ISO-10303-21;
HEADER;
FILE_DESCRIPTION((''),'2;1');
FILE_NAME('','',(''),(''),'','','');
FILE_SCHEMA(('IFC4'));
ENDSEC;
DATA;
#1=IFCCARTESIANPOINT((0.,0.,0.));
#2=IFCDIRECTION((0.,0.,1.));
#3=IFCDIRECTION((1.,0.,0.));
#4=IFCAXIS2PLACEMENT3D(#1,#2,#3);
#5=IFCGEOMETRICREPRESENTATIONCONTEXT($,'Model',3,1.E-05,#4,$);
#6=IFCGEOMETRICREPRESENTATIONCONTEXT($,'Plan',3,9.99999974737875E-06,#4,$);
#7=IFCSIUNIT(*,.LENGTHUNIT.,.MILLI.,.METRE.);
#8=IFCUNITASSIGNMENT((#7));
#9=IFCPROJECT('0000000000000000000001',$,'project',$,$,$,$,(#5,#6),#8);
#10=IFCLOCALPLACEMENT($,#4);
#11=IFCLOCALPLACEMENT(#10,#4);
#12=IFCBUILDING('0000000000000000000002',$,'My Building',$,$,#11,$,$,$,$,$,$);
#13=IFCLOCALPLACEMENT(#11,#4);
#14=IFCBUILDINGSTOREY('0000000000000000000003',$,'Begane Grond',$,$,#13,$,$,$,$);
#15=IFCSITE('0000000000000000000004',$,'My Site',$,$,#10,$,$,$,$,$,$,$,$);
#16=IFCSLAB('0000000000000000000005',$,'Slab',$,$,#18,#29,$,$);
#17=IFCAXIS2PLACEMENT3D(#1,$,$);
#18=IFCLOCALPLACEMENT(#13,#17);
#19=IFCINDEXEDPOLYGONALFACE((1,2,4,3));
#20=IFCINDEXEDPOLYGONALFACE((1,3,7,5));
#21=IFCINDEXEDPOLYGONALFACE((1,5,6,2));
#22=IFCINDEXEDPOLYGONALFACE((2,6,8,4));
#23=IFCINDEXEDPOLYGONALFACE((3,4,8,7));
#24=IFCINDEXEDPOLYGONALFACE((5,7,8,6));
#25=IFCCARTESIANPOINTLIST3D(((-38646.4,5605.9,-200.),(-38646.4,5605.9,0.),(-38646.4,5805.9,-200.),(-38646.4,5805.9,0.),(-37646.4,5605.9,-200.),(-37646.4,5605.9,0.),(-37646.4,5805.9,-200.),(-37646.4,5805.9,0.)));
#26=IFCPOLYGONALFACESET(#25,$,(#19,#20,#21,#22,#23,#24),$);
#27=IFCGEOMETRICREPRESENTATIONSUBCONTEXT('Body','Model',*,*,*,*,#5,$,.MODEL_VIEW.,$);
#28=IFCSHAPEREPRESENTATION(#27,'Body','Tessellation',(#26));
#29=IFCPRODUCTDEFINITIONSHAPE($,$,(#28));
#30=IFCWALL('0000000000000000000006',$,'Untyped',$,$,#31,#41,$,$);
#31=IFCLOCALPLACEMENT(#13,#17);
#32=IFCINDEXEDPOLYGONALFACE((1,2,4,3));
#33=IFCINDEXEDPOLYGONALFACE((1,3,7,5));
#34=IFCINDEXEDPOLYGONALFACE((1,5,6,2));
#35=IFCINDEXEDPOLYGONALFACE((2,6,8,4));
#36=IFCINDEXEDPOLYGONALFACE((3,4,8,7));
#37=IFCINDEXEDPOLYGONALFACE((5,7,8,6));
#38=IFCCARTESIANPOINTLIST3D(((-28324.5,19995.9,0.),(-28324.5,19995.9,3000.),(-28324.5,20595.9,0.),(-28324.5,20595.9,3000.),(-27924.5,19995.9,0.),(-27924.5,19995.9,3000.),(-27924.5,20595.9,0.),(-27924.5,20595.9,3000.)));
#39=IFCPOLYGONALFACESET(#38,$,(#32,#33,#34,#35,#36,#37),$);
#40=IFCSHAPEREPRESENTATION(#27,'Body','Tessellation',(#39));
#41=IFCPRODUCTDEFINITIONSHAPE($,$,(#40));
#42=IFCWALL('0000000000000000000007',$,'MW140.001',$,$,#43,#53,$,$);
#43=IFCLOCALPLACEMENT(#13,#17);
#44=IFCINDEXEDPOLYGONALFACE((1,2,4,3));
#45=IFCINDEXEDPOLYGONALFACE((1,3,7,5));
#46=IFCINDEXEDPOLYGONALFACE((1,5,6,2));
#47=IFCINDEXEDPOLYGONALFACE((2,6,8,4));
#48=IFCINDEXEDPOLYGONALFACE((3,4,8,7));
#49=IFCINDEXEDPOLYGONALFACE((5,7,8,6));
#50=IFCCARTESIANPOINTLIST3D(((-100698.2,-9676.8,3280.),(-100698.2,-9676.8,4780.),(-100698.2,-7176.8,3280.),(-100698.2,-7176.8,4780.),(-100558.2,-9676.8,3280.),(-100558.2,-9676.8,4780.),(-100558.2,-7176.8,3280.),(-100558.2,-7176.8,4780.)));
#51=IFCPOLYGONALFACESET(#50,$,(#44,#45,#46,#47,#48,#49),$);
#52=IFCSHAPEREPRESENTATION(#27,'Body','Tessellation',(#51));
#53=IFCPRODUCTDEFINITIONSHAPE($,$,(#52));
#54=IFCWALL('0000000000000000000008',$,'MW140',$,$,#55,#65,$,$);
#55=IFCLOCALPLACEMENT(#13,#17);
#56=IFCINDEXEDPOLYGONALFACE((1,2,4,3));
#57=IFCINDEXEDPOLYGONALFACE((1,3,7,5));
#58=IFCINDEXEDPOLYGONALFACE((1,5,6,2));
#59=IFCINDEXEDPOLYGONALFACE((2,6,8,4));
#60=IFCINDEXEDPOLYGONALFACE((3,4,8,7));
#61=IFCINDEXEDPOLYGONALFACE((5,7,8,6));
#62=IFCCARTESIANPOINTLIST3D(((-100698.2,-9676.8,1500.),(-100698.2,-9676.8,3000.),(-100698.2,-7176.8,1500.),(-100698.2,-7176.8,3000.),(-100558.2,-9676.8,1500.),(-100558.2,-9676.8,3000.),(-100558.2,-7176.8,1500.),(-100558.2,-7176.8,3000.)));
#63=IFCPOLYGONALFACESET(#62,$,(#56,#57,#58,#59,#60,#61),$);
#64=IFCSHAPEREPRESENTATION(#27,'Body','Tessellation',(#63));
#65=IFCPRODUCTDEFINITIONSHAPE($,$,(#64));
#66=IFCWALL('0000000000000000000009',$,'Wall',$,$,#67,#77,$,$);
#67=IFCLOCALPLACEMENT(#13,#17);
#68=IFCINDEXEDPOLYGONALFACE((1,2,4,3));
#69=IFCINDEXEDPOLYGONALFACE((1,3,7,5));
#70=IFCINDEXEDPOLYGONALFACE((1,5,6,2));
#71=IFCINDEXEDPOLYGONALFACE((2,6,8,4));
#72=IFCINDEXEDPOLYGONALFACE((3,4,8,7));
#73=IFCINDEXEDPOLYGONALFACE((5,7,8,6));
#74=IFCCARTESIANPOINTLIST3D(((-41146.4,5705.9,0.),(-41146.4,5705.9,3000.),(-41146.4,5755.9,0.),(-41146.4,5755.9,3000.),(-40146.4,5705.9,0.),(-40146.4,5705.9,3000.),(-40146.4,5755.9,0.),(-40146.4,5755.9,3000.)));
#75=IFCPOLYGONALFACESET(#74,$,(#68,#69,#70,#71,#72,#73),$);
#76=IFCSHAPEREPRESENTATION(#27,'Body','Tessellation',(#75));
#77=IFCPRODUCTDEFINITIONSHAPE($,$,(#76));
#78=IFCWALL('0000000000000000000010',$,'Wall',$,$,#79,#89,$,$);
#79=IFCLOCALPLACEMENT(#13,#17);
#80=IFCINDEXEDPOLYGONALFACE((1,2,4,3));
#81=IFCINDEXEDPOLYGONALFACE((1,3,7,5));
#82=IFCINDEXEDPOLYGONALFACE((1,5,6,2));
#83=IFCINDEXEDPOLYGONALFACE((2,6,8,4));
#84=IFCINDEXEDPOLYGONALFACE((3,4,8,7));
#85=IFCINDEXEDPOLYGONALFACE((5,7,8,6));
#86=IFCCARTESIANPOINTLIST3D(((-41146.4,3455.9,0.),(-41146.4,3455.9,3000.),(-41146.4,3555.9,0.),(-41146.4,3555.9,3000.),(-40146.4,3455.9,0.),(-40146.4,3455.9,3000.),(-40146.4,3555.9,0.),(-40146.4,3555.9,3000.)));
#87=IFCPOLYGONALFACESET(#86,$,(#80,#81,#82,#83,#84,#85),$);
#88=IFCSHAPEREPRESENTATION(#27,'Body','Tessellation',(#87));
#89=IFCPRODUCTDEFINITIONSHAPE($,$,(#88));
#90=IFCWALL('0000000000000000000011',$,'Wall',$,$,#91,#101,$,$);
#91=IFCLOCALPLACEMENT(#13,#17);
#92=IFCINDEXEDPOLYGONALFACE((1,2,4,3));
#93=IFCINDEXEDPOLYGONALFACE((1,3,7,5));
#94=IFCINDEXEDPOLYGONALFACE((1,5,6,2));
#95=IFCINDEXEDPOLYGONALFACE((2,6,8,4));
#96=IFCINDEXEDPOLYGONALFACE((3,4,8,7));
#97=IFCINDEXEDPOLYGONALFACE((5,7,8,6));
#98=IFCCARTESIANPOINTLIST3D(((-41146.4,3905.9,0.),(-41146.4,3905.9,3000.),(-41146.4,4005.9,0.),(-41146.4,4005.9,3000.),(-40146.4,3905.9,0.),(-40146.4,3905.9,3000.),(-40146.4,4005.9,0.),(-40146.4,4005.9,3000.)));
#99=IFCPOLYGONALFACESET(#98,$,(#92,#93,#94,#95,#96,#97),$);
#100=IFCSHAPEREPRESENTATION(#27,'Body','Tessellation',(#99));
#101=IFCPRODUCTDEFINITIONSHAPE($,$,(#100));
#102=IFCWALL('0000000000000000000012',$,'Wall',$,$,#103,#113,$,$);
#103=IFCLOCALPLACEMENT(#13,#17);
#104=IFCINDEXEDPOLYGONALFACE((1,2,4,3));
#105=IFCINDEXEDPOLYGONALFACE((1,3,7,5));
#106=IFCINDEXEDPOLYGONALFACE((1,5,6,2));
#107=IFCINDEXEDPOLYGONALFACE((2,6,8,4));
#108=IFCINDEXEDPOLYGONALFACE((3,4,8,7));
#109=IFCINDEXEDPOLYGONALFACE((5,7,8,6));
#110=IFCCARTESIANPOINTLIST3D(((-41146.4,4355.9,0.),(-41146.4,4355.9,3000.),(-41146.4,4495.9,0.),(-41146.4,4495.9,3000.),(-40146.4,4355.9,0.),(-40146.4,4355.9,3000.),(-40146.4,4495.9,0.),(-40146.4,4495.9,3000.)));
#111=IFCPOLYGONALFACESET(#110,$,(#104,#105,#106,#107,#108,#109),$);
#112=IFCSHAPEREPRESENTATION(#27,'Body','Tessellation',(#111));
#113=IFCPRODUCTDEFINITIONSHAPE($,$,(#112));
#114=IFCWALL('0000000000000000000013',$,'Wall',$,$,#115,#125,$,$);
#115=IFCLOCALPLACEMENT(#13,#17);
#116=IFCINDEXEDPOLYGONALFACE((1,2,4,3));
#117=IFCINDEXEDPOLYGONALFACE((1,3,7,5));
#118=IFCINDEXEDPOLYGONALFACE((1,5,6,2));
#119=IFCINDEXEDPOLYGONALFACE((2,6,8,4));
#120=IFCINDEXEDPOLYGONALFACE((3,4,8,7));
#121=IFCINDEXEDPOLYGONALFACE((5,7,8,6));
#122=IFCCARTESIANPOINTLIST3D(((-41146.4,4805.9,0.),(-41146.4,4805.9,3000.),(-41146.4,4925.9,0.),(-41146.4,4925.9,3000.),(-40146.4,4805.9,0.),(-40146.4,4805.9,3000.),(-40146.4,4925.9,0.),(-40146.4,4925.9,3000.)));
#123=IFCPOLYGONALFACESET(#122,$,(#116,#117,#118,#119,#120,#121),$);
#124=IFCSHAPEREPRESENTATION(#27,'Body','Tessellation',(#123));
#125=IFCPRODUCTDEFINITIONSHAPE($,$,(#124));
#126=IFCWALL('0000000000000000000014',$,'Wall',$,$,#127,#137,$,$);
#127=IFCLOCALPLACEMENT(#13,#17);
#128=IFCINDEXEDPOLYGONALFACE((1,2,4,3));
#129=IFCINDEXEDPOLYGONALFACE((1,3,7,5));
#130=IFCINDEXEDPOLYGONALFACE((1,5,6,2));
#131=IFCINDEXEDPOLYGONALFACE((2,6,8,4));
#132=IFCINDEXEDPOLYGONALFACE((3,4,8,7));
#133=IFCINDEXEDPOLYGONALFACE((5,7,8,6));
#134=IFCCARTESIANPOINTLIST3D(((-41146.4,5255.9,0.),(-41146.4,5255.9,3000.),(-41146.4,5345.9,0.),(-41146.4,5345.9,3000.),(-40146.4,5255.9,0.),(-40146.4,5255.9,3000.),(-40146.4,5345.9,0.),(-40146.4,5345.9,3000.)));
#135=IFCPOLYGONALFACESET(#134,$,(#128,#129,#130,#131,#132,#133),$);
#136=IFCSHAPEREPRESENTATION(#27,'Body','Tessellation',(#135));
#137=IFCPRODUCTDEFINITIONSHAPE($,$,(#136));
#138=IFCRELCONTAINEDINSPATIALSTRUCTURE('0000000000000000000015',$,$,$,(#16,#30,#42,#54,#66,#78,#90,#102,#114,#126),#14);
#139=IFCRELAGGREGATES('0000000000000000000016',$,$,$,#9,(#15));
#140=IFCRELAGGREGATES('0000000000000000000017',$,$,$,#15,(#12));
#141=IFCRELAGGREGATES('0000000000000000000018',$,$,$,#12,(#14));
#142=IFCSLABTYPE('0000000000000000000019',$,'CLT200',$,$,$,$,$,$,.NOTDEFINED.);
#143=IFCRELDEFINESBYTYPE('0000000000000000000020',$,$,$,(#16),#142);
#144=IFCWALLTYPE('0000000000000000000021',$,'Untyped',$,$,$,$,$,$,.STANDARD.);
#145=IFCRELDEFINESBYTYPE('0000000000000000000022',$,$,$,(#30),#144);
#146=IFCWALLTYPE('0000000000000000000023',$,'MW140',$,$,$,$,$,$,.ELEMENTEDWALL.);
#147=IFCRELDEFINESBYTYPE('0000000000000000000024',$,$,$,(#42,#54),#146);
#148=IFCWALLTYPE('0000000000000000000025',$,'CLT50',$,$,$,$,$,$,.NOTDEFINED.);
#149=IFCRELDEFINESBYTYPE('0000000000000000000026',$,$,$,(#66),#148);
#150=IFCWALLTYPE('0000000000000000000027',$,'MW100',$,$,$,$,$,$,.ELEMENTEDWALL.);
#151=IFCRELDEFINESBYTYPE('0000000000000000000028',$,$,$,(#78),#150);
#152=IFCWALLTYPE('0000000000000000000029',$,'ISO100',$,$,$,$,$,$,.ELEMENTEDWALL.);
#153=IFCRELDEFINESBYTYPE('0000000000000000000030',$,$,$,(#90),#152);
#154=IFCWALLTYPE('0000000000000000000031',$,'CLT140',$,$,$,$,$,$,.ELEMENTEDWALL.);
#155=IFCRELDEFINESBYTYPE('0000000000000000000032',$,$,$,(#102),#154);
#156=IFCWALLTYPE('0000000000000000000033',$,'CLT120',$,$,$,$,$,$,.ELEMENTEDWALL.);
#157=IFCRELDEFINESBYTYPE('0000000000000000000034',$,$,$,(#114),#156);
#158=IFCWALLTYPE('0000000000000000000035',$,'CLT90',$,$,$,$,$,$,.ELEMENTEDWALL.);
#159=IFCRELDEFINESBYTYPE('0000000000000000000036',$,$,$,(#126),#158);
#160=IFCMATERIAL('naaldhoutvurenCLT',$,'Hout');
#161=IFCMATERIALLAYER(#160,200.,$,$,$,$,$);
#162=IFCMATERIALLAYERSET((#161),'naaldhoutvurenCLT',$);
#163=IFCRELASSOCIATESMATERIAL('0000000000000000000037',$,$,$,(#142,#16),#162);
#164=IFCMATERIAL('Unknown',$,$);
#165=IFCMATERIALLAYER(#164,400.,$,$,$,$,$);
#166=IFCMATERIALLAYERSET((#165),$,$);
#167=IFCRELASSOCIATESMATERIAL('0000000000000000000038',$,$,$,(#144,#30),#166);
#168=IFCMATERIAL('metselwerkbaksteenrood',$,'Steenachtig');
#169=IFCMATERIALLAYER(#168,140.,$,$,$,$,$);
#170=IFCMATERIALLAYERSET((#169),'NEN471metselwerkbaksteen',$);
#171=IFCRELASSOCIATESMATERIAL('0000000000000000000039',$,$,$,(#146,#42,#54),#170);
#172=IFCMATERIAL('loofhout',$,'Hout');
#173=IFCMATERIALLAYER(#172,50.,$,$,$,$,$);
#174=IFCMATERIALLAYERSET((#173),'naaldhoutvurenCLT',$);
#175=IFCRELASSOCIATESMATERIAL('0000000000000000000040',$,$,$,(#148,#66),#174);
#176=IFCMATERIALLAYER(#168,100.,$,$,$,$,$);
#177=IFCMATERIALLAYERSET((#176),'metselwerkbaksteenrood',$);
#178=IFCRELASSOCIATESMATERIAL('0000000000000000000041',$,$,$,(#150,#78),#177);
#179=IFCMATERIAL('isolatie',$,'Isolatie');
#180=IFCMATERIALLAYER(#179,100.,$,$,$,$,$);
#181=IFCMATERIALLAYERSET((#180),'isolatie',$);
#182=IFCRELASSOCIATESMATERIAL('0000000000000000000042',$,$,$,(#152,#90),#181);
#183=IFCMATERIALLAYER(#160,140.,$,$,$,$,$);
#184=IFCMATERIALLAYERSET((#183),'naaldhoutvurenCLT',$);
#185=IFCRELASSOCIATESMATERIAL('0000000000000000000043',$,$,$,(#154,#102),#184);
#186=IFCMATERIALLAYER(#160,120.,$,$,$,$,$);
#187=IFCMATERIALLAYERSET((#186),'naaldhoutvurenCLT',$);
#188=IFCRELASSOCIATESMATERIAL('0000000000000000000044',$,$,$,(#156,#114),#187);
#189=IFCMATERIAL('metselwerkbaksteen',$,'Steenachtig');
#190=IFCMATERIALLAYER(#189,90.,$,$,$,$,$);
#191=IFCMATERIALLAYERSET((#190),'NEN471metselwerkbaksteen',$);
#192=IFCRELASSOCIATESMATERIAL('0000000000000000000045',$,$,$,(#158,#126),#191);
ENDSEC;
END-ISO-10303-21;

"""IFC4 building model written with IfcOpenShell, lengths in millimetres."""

from ifc_helpers import new_model, si_unit, frame, origin_with_axes, place, context, subcontext, project, spatial, line, indexed_curve, outline, extrude, material, layer, layer_set, layer_usage, type_object, element, save


model = new_model("IFC4")

# Units and contexts
model_context = context("Model", 3, precision=1e-05, world=origin_with_axes())
plan_context = context("Plan", 3, precision=9.99999974737875e-06, world=origin_with_axes())
body_context = subcontext(model_context, "Body", "Model", "MODEL_VIEW")
ifc_project = project(units=[si_unit("LENGTHUNIT", "METRE", prefix="MILLI")], contexts=[model_context, plan_context])

# Site, building, storey
site_placement = place(None, frame((0.0, 0.0, 0.0), z_axis=(0.0, 0.0, 1.0), x_axis=(1.0, 0.0, 0.0)))
site = spatial("IfcSite", under=ifc_project, at=site_placement, Name="My Site")
building_placement = place(site_placement, origin_with_axes())
building = spatial("IfcBuilding", under=site, at=building_placement, Name="My Building")
storey_placement = place(building_placement, origin_with_axes())
storey = spatial("IfcBuildingStorey", under=building, at=storey_placement, Name="Begane Grond")

# Slab
ifc_material_1 = material(Name="naaldhoutvurenCLT", Category="Hout")
ifc_material_2 = material(Name="isolatie", Category="Isolatie")
ifc_layer_1 = layer(ifc_material_1, 200.0)
ifc_layer_set_1 = layer_set([ifc_layer_1], Name="naaldhoutvurenCLT")
ifc_layer_usage_1 = layer_usage(ifc_layer_set_1, "AXIS3", "POSITIVE", 0.0)
slab_type_1 = type_object("IfcSlabType", Name="CLT200", PredefinedType="NOTDEFINED", material=ifc_layer_set_1)
slab_1_placement = place(storey_placement, frame((-38646.4, 5605.9, -200.0), z_axis=(0.0, 0.0, 1.0), x_axis=(1.0, 0.0, 0.0)))
element("IfcSlab", 1, at=slab_1_placement, inside=storey, type_object=slab_type_1, material=ifc_layer_usage_1, Name="Slab", context=body_context, shape_type="SweptSolid", body=[
    extrude(outline(indexed_curve([(1000.0, 200.0), (1000.0, 0.0), (0.0, 0.0), (0.0, 200.0)], segments=[line(3, 2), line(2, 1), line(1, 4), line(4, 3)], self_intersect=False)), None, (0.0, 0.0, 1.0), 200.0),
])

# Walls
ifc_material_3 = material(Name="Unknown")
ifc_layer_2 = layer(ifc_material_3, 400.0)
ifc_layer_set_2 = layer_set([ifc_layer_2])
ifc_layer_usage_2 = layer_usage(ifc_layer_set_2, "AXIS2", "POSITIVE", 0.0)
wall_type_1 = type_object("IfcWallType", Name="Untyped", PredefinedType="STANDARD", material=ifc_layer_set_2)
wall_1_placement = place(storey_placement, frame((-27924.5, 19995.9, 0.0), z_axis=(0.0, 0.0, 1.0), x_axis=(0.0, 1.0, 0.0)))
element("IfcWall", 2, at=wall_1_placement, inside=storey, type_object=wall_type_1, material=ifc_layer_usage_2, Name="Untyped", context=body_context, shape_type="SweptSolid", body=[
    extrude(outline(indexed_curve([(0.0, 0.0), (0.0, 400.0), (600.0, 400.0), (600.0, 0.0), (0.0, 0.0)], self_intersect=False)), origin_with_axes(), (0.0, 0.0, 1.0), 3000.0),
])
ifc_material_4 = material(Name="metselwerkbaksteenrood", Category="Steenachtig")
ifc_layer_3 = layer(ifc_material_4, 140.0)
ifc_layer_set_3 = layer_set([ifc_layer_3], Name="NEN471metselwerkbaksteen")
ifc_layer_usage_3 = layer_usage(ifc_layer_set_3, "AXIS2", "POSITIVE", 0.0)
wall_type_2 = type_object("IfcWallType", Name="MW140", PredefinedType="ELEMENTEDWALL", material=ifc_layer_set_3)
wall_2_placement = place(storey_placement, frame((-100558.2, -9676.8, 3280.0), z_axis=(0.0, 0.0, 1.0), x_axis=(0.0, 1.0, 0.0)))
element("IfcWall", 3, at=wall_2_placement, inside=storey, type_object=wall_type_2, material=ifc_layer_usage_3, Name="MW140.001", context=body_context, shape_type="SweptSolid", body=[
    extrude(outline(indexed_curve([(0.0, 0.0), (0.0, 140.0), (2500.0, 140.0), (2500.0, 0.0), (0.0, 0.0)], self_intersect=False)), origin_with_axes(), (0.0, 0.0, 1.0), 1500.0),
])
ifc_layer_usage_4 = layer_usage(ifc_layer_set_3, "AXIS2", "POSITIVE", 0.0)
wall_3_placement = place(storey_placement, frame((-100558.2, -9676.8, 1500.0), z_axis=(0.0, 0.0, 1.0), x_axis=(0.0, 1.0, 0.0)))
element("IfcWall", 4, at=wall_3_placement, inside=storey, type_object=wall_type_2, material=ifc_layer_usage_4, Name="MW140", context=body_context, shape_type="SweptSolid", body=[
    extrude(outline(indexed_curve([(0.0, 0.0), (0.0, 140.0), (2500.0, 140.0), (2500.0, 0.0), (0.0, 0.0)], self_intersect=False)), origin_with_axes(), (0.0, 0.0, 1.0), 1500.0),
])
ifc_material_5 = material(Name="loofhout", Category="Hout")
ifc_layer_4 = layer(ifc_material_5, 50.0)
ifc_layer_set_4 = layer_set([ifc_layer_4], Name="naaldhoutvurenCLT")
ifc_layer_usage_5 = layer_usage(ifc_layer_set_4, "AXIS2", "POSITIVE", 0.0)
wall_type_3 = type_object("IfcWallType", Name="CLT50", PredefinedType="NOTDEFINED", material=ifc_layer_set_4)
wall_4_placement = place(storey_placement, frame((-41146.4, 5705.9, 0.0), z_axis=(0.0, 0.0, 1.0), x_axis=(1.0, 0.0, 0.0)))
element("IfcWall", 5, at=wall_4_placement, inside=storey, type_object=wall_type_3, material=ifc_layer_usage_5, Name="Wall", context=body_context, shape_type="SweptSolid", body=[
    extrude(outline(indexed_curve([(0.0, 0.0), (0.0, 50.0), (1000.0, 50.0), (1000.0, 0.0), (0.0, 0.0)], self_intersect=False)), origin_with_axes(), (0.0, 0.0, 1.0), 3000.0),
])
ifc_layer_5 = layer(ifc_material_4, 100.0)
ifc_layer_set_5 = layer_set([ifc_layer_5], Name="metselwerkbaksteenrood")
ifc_layer_usage_6 = layer_usage(ifc_layer_set_5, "AXIS2", "POSITIVE", 0.0)
wall_type_4 = type_object("IfcWallType", Name="MW100", PredefinedType="ELEMENTEDWALL", material=ifc_layer_set_5)
wall_5_placement = place(storey_placement, frame((-41146.4, 3455.9, 0.0), z_axis=(0.0, 0.0, 1.0), x_axis=(1.0, 0.0, 0.0)))
element("IfcWall", 6, at=wall_5_placement, inside=storey, type_object=wall_type_4, material=ifc_layer_usage_6, Name="Wall", context=body_context, shape_type="SweptSolid", body=[
    extrude(outline(indexed_curve([(0.0, 0.0), (0.0, 100.0), (1000.0, 100.0), (1000.0, 0.0), (0.0, 0.0)], self_intersect=False)), origin_with_axes(), (0.0, 0.0, 1.0), 3000.0),
])
ifc_layer_6 = layer(ifc_material_2, 100.0)
ifc_layer_set_6 = layer_set([ifc_layer_6], Name="isolatie")
ifc_layer_usage_7 = layer_usage(ifc_layer_set_6, "AXIS2", "POSITIVE", 0.0)
wall_type_5 = type_object("IfcWallType", Name="ISO100", PredefinedType="ELEMENTEDWALL", material=ifc_layer_set_6)
wall_6_placement = place(storey_placement, frame((-41146.4, 3905.9, 0.0), z_axis=(0.0, 0.0, 1.0), x_axis=(1.0, 0.0, 0.0)))
element("IfcWall", 7, at=wall_6_placement, inside=storey, type_object=wall_type_5, material=ifc_layer_usage_7, Name="Wall", context=body_context, shape_type="SweptSolid", body=[
    extrude(outline(indexed_curve([(0.0, 0.0), (0.0, 100.0), (1000.0, 100.0), (1000.0, 0.0), (0.0, 0.0)], self_intersect=False)), origin_with_axes(), (0.0, 0.0, 1.0), 3000.0),
])
ifc_layer_7 = layer(ifc_material_1, 140.0)
ifc_layer_set_7 = layer_set([ifc_layer_7], Name="naaldhoutvurenCLT")
ifc_layer_usage_8 = layer_usage(ifc_layer_set_7, "AXIS2", "POSITIVE", 0.0)
wall_type_6 = type_object("IfcWallType", Name="CLT140", PredefinedType="ELEMENTEDWALL", material=ifc_layer_set_7)
wall_7_placement = place(storey_placement, frame((-41146.4, 4355.9, 0.0), z_axis=(0.0, 0.0, 1.0), x_axis=(1.0, 0.0, 0.0)))
element("IfcWall", 8, at=wall_7_placement, inside=storey, type_object=wall_type_6, material=ifc_layer_usage_8, Name="Wall", context=body_context, shape_type="SweptSolid", body=[
    extrude(outline(indexed_curve([(0.0, 0.0), (0.0, 140.0), (1000.0, 140.0), (1000.0, 0.0), (0.0, 0.0)], self_intersect=False)), origin_with_axes(), (0.0, 0.0, 1.0), 3000.0),
])
ifc_layer_8 = layer(ifc_material_1, 120.0)
ifc_layer_set_8 = layer_set([ifc_layer_8], Name="naaldhoutvurenCLT")
ifc_layer_usage_9 = layer_usage(ifc_layer_set_8, "AXIS2", "POSITIVE", 0.0)
wall_type_7 = type_object("IfcWallType", Name="CLT120", PredefinedType="ELEMENTEDWALL", material=ifc_layer_set_8)
wall_8_placement = place(storey_placement, frame((-41146.4, 4805.9, 0.0), z_axis=(0.0, 0.0, 1.0), x_axis=(1.0, 0.0, 0.0)))
element("IfcWall", 9, at=wall_8_placement, inside=storey, type_object=wall_type_7, material=ifc_layer_usage_9, Name="Wall", context=body_context, shape_type="SweptSolid", body=[
    extrude(outline(indexed_curve([(0.0, 0.0), (0.0, 120.0), (1000.0, 120.0), (1000.0, 0.0), (0.0, 0.0)], self_intersect=False)), origin_with_axes(), (0.0, 0.0, 1.0), 3000.0),
])
ifc_material_6 = material(Name="metselwerkbaksteen", Category="Steenachtig")
ifc_layer_9 = layer(ifc_material_6, 90.0)
ifc_layer_set_9 = layer_set([ifc_layer_9], Name="NEN471metselwerkbaksteen")
ifc_layer_usage_10 = layer_usage(ifc_layer_set_9, "AXIS2", "POSITIVE", 0.0)
wall_type_8 = type_object("IfcWallType", Name="CLT90", PredefinedType="ELEMENTEDWALL", material=ifc_layer_set_9)
wall_9_placement = place(storey_placement, frame((-41146.4, 5255.9, 0.0), z_axis=(0.0, 0.0, 1.0), x_axis=(1.0, 0.0, 0.0)))
element("IfcWall", 10, at=wall_9_placement, inside=storey, type_object=wall_type_8, material=ifc_layer_usage_10, Name="Wall", context=body_context, shape_type="SweptSolid", body=[
    extrude(outline(indexed_curve([(0.0, 0.0), (0.0, 90.0), (1000.0, 90.0), (1000.0, 0.0), (0.0, 0.0)], self_intersect=False)), origin_with_axes(), (0.0, 0.0, 1.0), 3000.0),
])

save(model, "model.ifc")
